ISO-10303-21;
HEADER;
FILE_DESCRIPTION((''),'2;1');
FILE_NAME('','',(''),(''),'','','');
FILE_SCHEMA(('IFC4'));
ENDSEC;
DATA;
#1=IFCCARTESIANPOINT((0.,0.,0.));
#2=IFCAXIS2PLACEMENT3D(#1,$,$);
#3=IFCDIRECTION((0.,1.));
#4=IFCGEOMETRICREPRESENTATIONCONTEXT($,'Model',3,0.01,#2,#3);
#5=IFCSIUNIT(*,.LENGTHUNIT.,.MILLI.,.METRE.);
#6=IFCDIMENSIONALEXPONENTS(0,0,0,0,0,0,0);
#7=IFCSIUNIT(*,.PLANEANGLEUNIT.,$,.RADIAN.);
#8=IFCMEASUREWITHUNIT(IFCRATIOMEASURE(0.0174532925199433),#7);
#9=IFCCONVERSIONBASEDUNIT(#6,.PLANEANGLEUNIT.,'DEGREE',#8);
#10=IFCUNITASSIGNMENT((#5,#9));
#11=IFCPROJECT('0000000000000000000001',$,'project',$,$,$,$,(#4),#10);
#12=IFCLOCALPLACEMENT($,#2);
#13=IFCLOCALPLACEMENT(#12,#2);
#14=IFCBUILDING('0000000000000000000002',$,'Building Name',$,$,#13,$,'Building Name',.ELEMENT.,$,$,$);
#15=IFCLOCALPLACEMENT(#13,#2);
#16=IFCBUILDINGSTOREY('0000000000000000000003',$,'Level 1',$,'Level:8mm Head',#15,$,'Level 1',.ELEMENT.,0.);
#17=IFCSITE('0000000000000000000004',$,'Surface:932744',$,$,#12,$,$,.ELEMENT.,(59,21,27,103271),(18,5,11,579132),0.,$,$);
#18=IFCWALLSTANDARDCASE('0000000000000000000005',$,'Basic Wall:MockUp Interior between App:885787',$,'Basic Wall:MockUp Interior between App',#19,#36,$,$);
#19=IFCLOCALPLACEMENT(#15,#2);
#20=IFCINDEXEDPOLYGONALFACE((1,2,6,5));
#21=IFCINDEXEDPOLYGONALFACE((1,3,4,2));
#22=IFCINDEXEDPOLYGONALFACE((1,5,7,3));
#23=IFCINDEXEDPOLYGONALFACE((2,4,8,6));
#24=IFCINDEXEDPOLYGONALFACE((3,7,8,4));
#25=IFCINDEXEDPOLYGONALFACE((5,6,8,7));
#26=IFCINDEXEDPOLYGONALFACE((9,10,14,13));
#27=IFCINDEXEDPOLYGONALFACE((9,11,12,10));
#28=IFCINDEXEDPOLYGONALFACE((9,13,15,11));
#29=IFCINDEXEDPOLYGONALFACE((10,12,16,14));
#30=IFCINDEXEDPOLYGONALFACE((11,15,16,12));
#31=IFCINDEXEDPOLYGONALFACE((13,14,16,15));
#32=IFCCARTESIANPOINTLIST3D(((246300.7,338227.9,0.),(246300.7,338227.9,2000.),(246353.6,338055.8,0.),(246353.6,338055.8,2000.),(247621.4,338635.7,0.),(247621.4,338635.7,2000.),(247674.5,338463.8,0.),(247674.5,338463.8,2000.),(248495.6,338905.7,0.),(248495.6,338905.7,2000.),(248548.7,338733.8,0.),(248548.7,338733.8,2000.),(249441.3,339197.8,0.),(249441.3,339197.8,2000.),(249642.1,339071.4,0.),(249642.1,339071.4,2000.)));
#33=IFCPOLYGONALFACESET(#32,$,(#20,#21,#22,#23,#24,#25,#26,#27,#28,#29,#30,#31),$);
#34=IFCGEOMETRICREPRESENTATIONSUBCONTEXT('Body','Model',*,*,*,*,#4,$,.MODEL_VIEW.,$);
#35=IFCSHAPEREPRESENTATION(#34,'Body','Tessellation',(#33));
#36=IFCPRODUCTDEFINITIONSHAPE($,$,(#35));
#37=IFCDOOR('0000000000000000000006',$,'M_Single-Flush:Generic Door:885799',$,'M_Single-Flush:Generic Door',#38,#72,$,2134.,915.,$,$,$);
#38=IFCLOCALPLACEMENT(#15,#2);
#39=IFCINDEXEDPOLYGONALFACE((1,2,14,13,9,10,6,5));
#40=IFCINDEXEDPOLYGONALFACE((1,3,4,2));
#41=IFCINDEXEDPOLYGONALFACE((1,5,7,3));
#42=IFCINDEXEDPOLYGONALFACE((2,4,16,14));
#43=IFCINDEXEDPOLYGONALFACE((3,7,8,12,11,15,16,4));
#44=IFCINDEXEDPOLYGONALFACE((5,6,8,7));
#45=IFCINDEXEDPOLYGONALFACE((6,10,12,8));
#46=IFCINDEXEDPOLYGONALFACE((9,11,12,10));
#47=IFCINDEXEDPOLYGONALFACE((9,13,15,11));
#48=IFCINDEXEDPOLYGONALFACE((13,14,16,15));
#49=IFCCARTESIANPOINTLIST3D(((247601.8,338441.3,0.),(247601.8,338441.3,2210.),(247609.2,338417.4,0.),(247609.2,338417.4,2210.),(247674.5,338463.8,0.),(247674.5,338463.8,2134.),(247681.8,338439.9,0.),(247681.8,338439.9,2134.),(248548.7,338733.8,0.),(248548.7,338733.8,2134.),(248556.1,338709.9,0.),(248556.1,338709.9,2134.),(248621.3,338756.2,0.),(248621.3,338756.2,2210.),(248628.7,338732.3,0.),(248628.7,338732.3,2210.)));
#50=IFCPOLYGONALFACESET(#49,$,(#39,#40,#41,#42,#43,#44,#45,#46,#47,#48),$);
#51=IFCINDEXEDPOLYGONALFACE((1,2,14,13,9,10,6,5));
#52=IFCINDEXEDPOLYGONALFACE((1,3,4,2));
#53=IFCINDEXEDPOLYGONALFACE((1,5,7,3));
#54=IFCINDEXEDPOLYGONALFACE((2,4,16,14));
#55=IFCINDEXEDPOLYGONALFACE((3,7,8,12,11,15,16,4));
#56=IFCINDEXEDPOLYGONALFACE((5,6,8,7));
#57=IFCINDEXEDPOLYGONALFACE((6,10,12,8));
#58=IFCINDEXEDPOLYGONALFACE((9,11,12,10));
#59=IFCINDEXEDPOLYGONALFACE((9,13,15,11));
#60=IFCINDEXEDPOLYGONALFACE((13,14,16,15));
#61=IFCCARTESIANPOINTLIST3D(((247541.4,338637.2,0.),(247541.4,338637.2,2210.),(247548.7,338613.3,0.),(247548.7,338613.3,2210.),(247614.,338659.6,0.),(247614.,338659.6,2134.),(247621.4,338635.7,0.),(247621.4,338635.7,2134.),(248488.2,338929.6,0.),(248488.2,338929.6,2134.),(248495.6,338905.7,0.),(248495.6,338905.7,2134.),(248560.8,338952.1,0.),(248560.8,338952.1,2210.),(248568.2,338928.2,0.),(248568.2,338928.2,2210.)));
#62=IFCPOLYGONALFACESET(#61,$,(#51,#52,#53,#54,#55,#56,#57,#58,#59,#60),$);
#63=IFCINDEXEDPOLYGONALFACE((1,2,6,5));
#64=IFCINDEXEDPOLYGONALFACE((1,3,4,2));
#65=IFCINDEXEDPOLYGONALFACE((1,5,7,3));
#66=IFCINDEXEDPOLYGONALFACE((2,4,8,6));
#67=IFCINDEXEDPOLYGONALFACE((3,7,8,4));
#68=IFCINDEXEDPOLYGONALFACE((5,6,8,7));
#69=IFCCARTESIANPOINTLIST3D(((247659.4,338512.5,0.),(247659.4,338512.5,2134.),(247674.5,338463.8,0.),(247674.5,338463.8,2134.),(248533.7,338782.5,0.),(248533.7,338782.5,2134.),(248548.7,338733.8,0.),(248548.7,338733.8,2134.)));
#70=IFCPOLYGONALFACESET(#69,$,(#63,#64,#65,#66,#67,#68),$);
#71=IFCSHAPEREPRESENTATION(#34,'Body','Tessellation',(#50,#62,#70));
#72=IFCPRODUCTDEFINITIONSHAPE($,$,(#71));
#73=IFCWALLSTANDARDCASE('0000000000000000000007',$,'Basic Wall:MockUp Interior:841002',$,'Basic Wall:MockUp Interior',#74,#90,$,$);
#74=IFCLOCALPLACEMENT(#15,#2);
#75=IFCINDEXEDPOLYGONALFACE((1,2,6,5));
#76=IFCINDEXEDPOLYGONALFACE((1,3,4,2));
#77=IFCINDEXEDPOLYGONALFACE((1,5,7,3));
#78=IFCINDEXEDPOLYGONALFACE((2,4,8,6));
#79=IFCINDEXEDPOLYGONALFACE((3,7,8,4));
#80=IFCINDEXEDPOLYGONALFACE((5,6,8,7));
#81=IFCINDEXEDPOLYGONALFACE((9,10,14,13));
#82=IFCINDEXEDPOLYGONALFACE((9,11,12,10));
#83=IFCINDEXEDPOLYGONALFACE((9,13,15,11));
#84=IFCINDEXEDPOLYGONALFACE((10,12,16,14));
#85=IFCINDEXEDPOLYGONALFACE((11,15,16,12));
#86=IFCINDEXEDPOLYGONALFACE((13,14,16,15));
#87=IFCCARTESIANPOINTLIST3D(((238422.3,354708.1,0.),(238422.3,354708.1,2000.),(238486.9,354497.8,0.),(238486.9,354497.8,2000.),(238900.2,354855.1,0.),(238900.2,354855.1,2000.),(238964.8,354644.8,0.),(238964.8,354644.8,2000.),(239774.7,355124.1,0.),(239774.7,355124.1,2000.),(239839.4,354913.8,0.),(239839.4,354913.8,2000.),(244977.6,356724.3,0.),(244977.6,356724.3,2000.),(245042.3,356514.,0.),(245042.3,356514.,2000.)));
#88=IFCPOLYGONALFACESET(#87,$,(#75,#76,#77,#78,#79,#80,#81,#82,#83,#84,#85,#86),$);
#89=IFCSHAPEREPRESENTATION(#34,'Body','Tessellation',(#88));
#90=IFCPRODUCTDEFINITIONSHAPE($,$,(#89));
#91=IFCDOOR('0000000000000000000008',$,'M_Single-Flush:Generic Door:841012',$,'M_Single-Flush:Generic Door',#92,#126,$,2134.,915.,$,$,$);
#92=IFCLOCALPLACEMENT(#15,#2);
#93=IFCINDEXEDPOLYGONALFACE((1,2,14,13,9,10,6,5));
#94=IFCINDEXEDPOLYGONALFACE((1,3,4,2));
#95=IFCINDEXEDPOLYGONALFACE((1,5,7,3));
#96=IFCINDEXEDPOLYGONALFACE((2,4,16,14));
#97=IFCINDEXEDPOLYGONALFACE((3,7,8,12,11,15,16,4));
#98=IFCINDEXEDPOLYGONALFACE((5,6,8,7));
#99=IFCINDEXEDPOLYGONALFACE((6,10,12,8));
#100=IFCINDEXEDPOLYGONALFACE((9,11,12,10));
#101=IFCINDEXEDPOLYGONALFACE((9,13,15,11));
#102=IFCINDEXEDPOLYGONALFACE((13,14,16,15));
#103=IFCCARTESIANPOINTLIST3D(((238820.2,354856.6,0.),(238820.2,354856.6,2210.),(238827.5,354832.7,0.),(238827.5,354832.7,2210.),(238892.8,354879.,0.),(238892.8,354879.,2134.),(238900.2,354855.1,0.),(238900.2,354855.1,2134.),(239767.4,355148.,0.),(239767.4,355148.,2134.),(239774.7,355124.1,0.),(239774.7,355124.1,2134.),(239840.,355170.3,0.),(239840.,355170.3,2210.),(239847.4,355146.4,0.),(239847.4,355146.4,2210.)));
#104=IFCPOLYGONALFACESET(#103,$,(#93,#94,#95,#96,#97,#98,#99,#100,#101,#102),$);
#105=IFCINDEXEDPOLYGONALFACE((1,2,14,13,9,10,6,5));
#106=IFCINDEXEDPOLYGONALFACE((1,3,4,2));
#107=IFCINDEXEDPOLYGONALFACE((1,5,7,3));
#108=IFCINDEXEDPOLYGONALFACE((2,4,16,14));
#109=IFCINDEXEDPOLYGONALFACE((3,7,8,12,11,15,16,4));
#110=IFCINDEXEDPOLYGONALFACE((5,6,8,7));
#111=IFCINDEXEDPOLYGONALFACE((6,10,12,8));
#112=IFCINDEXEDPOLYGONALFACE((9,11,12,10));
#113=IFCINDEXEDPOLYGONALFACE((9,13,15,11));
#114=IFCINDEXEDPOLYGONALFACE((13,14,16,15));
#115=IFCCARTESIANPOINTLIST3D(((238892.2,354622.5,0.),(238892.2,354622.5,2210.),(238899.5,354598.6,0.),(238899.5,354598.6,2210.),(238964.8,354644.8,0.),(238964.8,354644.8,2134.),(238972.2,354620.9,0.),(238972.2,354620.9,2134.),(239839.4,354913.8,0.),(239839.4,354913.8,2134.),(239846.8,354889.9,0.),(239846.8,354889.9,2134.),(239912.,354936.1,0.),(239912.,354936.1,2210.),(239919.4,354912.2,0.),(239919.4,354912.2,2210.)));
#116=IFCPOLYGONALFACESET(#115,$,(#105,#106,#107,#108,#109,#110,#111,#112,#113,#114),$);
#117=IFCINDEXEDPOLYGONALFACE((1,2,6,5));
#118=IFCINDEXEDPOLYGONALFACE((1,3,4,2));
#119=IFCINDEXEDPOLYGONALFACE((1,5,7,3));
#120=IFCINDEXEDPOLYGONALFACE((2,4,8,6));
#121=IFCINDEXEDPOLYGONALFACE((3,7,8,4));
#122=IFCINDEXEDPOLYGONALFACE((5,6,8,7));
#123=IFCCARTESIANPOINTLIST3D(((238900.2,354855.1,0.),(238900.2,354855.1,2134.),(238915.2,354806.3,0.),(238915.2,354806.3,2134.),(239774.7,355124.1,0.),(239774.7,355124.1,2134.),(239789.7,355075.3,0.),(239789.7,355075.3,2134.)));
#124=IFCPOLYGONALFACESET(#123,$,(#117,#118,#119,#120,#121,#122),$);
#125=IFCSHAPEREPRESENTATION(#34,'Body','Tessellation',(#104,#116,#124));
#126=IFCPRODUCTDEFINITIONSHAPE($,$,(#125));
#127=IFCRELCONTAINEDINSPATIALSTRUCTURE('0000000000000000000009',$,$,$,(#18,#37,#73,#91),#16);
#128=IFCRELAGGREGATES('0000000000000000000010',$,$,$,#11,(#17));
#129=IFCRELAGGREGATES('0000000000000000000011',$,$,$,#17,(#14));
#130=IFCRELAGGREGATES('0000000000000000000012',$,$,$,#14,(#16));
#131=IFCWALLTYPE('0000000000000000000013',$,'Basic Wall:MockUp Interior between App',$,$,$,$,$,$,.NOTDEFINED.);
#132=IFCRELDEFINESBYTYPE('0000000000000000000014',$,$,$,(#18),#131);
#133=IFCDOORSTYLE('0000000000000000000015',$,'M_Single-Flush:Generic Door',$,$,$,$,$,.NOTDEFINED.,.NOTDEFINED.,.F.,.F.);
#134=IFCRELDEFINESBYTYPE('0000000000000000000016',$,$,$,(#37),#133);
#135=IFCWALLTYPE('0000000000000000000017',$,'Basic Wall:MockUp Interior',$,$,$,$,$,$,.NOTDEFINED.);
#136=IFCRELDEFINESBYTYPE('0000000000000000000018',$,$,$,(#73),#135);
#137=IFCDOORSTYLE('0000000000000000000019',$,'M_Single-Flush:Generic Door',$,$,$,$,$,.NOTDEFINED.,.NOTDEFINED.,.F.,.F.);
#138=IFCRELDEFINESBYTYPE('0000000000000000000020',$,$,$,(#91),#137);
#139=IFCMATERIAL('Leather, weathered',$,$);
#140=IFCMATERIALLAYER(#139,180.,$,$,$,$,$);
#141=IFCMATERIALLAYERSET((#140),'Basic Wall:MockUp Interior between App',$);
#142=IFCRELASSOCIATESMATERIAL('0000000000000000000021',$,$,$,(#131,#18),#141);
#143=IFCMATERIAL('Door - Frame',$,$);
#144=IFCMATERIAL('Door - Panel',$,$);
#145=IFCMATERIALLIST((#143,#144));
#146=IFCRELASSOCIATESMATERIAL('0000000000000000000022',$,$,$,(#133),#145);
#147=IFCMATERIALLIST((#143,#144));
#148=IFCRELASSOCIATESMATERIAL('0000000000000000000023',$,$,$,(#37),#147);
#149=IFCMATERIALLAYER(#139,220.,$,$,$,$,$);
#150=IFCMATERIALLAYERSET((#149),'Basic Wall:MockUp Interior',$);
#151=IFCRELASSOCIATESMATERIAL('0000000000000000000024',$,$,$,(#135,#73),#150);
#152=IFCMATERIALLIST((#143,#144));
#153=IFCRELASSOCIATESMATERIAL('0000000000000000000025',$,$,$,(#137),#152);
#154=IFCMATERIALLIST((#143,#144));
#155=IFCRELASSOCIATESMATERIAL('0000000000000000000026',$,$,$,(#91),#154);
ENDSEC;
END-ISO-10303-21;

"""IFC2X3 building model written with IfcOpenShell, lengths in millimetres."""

from ifc_helpers import new_model, entity, si_unit, converted_unit, direction, frame, frame_2d, origin, place, context, subcontext, project, spatial, polyline, rectangle, outline, extrude, source, transform, mapped, material, material_list, layer, layer_set, layer_usage, type_object, type_shapes, element, fill, save


model = new_model("IFC2X3")

# Units and contexts
model_context = context("Model", 3, precision=0.01, world=origin(), true_north=direction((0.0, 1.0)))
body_context = subcontext(model_context, "Body", "Model", "MODEL_VIEW")
ifc_project = project(units=[si_unit("LENGTHUNIT", "METRE", prefix="MILLI"), converted_unit("PLANEANGLEUNIT", "DEGREE", entity("IfcRatioMeasure", 0.0174532925199433), si_unit("PLANEANGLEUNIT", "RADIAN"), dimensions=[0, 0, 0, 0, 0, 0, 0])], contexts=[model_context])

# Site, building, storey
site_placement = place(None, origin())
site = spatial("IfcSite", under=ifc_project, at=site_placement, Name="Surface:932744", CompositionType="ELEMENT", RefLatitude=(59, 21, 27, 103271), RefLongitude=(18, 5, 11, 579132), RefElevation=0.0)
building_placement = place(site_placement, origin())
building = spatial("IfcBuilding", under=site, at=building_placement, Name="Building Name", LongName="Building Name", CompositionType="ELEMENT")
storey_placement = place(building_placement, origin())
storey = spatial("IfcBuildingStorey", under=building, at=storey_placement, Name="Level 1", ObjectType="Level:8mm Head", LongName="Level 1", CompositionType="ELEMENT", Elevation=0.0)

# Shared definitions
ifc_material_1 = material(Name="Door - Frame")
ifc_material_2 = material(Name="Door - Panel")

# Wall, opening, door
ifc_material_3 = material(Name="Leather, weathered")
ifc_layer_1 = layer(ifc_material_3, 180.0)
ifc_layer_set_1 = layer_set([ifc_layer_1], Name="Basic Wall:MockUp Interior between App")
ifc_layer_usage_1 = layer_usage(ifc_layer_set_1, "AXIS2", "NEGATIVE", 90.0)
wall_type_1 = type_object("IfcWallType", Name="Basic Wall:MockUp Interior between App", PredefinedType="NOTDEFINED", material=ifc_layer_set_1)
wall_1_placement = place(building_placement, frame((246327.0, 338141.8, 0.0), z_axis=(0.0, 0.0, 1.0), x_axis=(0.955473, 0.29508, 0.0)))
wall_1 = element("IfcWallStandardCase", 1, at=wall_1_placement, inside=storey, type_object=wall_type_1, material=ifc_layer_usage_1, Name="Basic Wall:MockUp Interior between App:885787", ObjectType="Basic Wall:MockUp Interior between App", context=body_context, shape_type="SweptSolid", body=[
    extrude(outline(polyline([(0.2, 90.0), (0.0, -90.0), (3441.8, -90.0), (3287.2, 90.0), (0.2, 90.0)])), origin(), (0.0, 0.0, 1.0), 2000.0),
])
opening_1_placement = place(wall_1_placement, frame((2297.4, 90.0, 0.0)))
opening_1 = element("IfcOpeningElement", 2, at=opening_1_placement, cuts=wall_1, ObjectType="Opening", context=body_context, shape_type="SweptSolid", body=[
    extrude(rectangle(XDim=915.0, YDim=2134.0, at=frame_2d((1067.0, 457.5), x_axis=(0.0, 1.0))), frame((0.0, 0.0, 0.0), z_axis=(0.0, -1.0, 0.0), x_axis=(0.0, 0.0, 1.0)), (0.0, 0.0, 1.0), 180.0),
])
ifc_material_list_1 = material_list([ifc_material_1, ifc_material_2])
ifc_material_list_2 = material_list([ifc_material_1, ifc_material_2])
door_style_1 = type_object("IfcDoorStyle", Name="M_Single-Flush:Generic Door", ConstructionType="NOTDEFINED", OperationType="NOTDEFINED", ParameterTakesPrecedence=False, Sizeable=False, material=ifc_material_list_2)
shared_shape_1 = source(origin(), body_context, "Body", "SweptSolid", [
    extrude(outline(polyline([(-533.5, -1124.0), (533.5, -1124.0), (533.5, 1086.0), (457.5, 1086.0), (457.5, -1048.0), (-457.5, -1048.0), (-457.5, 1086.0), (-533.5, 1086.0), (-533.5, -1124.0)])), frame((457.5, 180.0, 1086.0), z_axis=(0.0, 1.0, 0.0), x_axis=(1.0, 0.0, 0.0)), (0.0, 0.0, 1.0), 25.0),
    extrude(outline(polyline([(-1124.0, -533.5), (1086.0, -533.5), (1086.0, -457.5), (-1048.0, -457.5), (-1048.0, 457.5), (1086.0, 457.5), (1086.0, 533.5), (-1124.0, 533.5), (-1124.0, -533.5)])), frame((457.5, -25.0, 1086.0), z_axis=(0.0, 1.0, 0.0), x_axis=(0.0, 0.0, -1.0)), (0.0, 0.0, 1.0), 25.0),
    extrude(rectangle(XDim=51.0, YDim=915.0, at=frame_2d((0.0, 0.0), x_axis=(1.0, 0.0))), frame((457.5, 154.5, 0.0), z_axis=(0.0, 0.0, 1.0), x_axis=(0.0, 1.0, 0.0)), (0.0, 0.0, 1.0), 2134.0),
])
type_shapes(door_style_1, [shared_shape_1])
door_1_placement = place(opening_1_placement, frame((0.0, 0.0, 0.0), z_axis=(0.0, 0.0, 1.0), x_axis=(-1.0, 0.0, 0.0)))
door_1 = element("IfcDoor", 3, at=door_1_placement, inside=storey, type_object=door_style_1, material=ifc_material_list_1, Name="M_Single-Flush:Generic Door:885799", ObjectType="M_Single-Flush:Generic Door", OverallHeight=2134.0, OverallWidth=915.0, context=body_context, shape_type="MappedRepresentation", body=[
    mapped(shared_shape_1, transform((0.0, 0.0, 0.0), scale=1.0)),
])
fill(opening_1, door_1)

# Shared definitions
ifc_layer_2 = layer(ifc_material_3, 220.0)
ifc_layer_set_2 = layer_set([ifc_layer_2], Name="Basic Wall:MockUp Interior")
wall_type_2 = type_object("IfcWallType", Name="Basic Wall:MockUp Interior", PredefinedType="NOTDEFINED", material=ifc_layer_set_2)
ifc_material_list_3 = material_list([ifc_material_1, ifc_material_2])
door_style_2 = type_object("IfcDoorStyle", Name="M_Single-Flush:Generic Door", ConstructionType="NOTDEFINED", OperationType="NOTDEFINED", ParameterTakesPrecedence=False, Sizeable=False, material=ifc_material_list_3)
shared_shape_2 = source(origin(), body_context, "Body", "SweptSolid", [
    extrude(outline(polyline([(-533.5, -1124.0), (533.5, -1124.0), (533.5, 1086.0), (457.5, 1086.0), (457.5, -1048.0), (-457.5, -1048.0), (-457.5, 1086.0), (-533.5, 1086.0), (-533.5, -1124.0)])), frame((457.5, 220.0, 1086.0), z_axis=(0.0, 1.0, 0.0), x_axis=(1.0, 0.0, 0.0)), (0.0, 0.0, 1.0), 25.0),
    extrude(outline(polyline([(-1124.0, -533.5), (1086.0, -533.5), (1086.0, -457.5), (-1048.0, -457.5), (-1048.0, 457.5), (1086.0, 457.5), (1086.0, 533.5), (-1124.0, 533.5), (-1124.0, -533.5)])), frame((457.5, -25.0, 1086.0), z_axis=(0.0, 1.0, 0.0), x_axis=(0.0, 0.0, -1.0)), (0.0, 0.0, 1.0), 25.0),
    extrude(rectangle(XDim=51.0, YDim=915.0, at=frame_2d((0.0, 0.0), x_axis=(1.0, 0.0))), frame((457.5, 194.5, 0.0), z_axis=(0.0, 0.0, 1.0), x_axis=(0.0, 1.0, 0.0)), (0.0, 0.0, 1.0), 2134.0),
])
type_shapes(door_style_2, [shared_shape_2])

# Wall, opening, door
ifc_layer_usage_2 = layer_usage(ifc_layer_set_2, "AXIS2", "NEGATIVE", 110.0)
wall_2_placement = place(building_placement, frame((245010.0, 356619.2, 0.0), z_axis=(0.0, 0.0, 1.0), x_axis=(-0.955811, -0.29398, 0.0)))
wall_2 = element("IfcWallStandardCase", 4, at=wall_2_placement, inside=storey, type_object=wall_type_2, material=ifc_layer_usage_2, Name="Basic Wall:MockUp Interior:841002", ObjectType="Basic Wall:MockUp Interior", context=body_context, shape_type="SweptSolid", body=[
    extrude(rectangle(XDim=6858.4, YDim=220.0, at=frame_2d((3429.2, 0.0), x_axis=(-1.0, 0.0))), origin(), (0.0, 0.0, 1.0), 2000.0),
])
opening_2_placement = place(wall_2_placement, frame((6358.4, 110.0, 0.0)))
opening_2 = element("IfcOpeningElement", 5, at=opening_2_placement, cuts=wall_2, ObjectType="Opening", context=body_context, shape_type="SweptSolid", body=[
    extrude(rectangle(XDim=915.0, YDim=2134.0, at=frame_2d((1067.0, 457.5), x_axis=(0.0, 1.0))), frame((0.0, 0.0, 0.0), z_axis=(0.0, -1.0, 0.0), x_axis=(0.0, 0.0, 1.0)), (0.0, 0.0, 1.0), 220.0),
])
ifc_material_list_4 = material_list([ifc_material_1, ifc_material_2])
door_2_placement = place(opening_2_placement, frame((0.0, 0.0, 0.0), z_axis=(0.0, 0.0, 1.0), x_axis=(-1.0, 0.0, 0.0)))
door_2 = element("IfcDoor", 6, at=door_2_placement, inside=storey, type_object=door_style_2, material=ifc_material_list_4, Name="M_Single-Flush:Generic Door:841012", ObjectType="M_Single-Flush:Generic Door", OverallHeight=2134.0, OverallWidth=915.0, context=body_context, shape_type="MappedRepresentation", body=[
    mapped(shared_shape_2, transform((0.0, 0.0, 0.0), scale=1.0)),
])
fill(opening_2, door_2)

save(model, "model.ifc")
